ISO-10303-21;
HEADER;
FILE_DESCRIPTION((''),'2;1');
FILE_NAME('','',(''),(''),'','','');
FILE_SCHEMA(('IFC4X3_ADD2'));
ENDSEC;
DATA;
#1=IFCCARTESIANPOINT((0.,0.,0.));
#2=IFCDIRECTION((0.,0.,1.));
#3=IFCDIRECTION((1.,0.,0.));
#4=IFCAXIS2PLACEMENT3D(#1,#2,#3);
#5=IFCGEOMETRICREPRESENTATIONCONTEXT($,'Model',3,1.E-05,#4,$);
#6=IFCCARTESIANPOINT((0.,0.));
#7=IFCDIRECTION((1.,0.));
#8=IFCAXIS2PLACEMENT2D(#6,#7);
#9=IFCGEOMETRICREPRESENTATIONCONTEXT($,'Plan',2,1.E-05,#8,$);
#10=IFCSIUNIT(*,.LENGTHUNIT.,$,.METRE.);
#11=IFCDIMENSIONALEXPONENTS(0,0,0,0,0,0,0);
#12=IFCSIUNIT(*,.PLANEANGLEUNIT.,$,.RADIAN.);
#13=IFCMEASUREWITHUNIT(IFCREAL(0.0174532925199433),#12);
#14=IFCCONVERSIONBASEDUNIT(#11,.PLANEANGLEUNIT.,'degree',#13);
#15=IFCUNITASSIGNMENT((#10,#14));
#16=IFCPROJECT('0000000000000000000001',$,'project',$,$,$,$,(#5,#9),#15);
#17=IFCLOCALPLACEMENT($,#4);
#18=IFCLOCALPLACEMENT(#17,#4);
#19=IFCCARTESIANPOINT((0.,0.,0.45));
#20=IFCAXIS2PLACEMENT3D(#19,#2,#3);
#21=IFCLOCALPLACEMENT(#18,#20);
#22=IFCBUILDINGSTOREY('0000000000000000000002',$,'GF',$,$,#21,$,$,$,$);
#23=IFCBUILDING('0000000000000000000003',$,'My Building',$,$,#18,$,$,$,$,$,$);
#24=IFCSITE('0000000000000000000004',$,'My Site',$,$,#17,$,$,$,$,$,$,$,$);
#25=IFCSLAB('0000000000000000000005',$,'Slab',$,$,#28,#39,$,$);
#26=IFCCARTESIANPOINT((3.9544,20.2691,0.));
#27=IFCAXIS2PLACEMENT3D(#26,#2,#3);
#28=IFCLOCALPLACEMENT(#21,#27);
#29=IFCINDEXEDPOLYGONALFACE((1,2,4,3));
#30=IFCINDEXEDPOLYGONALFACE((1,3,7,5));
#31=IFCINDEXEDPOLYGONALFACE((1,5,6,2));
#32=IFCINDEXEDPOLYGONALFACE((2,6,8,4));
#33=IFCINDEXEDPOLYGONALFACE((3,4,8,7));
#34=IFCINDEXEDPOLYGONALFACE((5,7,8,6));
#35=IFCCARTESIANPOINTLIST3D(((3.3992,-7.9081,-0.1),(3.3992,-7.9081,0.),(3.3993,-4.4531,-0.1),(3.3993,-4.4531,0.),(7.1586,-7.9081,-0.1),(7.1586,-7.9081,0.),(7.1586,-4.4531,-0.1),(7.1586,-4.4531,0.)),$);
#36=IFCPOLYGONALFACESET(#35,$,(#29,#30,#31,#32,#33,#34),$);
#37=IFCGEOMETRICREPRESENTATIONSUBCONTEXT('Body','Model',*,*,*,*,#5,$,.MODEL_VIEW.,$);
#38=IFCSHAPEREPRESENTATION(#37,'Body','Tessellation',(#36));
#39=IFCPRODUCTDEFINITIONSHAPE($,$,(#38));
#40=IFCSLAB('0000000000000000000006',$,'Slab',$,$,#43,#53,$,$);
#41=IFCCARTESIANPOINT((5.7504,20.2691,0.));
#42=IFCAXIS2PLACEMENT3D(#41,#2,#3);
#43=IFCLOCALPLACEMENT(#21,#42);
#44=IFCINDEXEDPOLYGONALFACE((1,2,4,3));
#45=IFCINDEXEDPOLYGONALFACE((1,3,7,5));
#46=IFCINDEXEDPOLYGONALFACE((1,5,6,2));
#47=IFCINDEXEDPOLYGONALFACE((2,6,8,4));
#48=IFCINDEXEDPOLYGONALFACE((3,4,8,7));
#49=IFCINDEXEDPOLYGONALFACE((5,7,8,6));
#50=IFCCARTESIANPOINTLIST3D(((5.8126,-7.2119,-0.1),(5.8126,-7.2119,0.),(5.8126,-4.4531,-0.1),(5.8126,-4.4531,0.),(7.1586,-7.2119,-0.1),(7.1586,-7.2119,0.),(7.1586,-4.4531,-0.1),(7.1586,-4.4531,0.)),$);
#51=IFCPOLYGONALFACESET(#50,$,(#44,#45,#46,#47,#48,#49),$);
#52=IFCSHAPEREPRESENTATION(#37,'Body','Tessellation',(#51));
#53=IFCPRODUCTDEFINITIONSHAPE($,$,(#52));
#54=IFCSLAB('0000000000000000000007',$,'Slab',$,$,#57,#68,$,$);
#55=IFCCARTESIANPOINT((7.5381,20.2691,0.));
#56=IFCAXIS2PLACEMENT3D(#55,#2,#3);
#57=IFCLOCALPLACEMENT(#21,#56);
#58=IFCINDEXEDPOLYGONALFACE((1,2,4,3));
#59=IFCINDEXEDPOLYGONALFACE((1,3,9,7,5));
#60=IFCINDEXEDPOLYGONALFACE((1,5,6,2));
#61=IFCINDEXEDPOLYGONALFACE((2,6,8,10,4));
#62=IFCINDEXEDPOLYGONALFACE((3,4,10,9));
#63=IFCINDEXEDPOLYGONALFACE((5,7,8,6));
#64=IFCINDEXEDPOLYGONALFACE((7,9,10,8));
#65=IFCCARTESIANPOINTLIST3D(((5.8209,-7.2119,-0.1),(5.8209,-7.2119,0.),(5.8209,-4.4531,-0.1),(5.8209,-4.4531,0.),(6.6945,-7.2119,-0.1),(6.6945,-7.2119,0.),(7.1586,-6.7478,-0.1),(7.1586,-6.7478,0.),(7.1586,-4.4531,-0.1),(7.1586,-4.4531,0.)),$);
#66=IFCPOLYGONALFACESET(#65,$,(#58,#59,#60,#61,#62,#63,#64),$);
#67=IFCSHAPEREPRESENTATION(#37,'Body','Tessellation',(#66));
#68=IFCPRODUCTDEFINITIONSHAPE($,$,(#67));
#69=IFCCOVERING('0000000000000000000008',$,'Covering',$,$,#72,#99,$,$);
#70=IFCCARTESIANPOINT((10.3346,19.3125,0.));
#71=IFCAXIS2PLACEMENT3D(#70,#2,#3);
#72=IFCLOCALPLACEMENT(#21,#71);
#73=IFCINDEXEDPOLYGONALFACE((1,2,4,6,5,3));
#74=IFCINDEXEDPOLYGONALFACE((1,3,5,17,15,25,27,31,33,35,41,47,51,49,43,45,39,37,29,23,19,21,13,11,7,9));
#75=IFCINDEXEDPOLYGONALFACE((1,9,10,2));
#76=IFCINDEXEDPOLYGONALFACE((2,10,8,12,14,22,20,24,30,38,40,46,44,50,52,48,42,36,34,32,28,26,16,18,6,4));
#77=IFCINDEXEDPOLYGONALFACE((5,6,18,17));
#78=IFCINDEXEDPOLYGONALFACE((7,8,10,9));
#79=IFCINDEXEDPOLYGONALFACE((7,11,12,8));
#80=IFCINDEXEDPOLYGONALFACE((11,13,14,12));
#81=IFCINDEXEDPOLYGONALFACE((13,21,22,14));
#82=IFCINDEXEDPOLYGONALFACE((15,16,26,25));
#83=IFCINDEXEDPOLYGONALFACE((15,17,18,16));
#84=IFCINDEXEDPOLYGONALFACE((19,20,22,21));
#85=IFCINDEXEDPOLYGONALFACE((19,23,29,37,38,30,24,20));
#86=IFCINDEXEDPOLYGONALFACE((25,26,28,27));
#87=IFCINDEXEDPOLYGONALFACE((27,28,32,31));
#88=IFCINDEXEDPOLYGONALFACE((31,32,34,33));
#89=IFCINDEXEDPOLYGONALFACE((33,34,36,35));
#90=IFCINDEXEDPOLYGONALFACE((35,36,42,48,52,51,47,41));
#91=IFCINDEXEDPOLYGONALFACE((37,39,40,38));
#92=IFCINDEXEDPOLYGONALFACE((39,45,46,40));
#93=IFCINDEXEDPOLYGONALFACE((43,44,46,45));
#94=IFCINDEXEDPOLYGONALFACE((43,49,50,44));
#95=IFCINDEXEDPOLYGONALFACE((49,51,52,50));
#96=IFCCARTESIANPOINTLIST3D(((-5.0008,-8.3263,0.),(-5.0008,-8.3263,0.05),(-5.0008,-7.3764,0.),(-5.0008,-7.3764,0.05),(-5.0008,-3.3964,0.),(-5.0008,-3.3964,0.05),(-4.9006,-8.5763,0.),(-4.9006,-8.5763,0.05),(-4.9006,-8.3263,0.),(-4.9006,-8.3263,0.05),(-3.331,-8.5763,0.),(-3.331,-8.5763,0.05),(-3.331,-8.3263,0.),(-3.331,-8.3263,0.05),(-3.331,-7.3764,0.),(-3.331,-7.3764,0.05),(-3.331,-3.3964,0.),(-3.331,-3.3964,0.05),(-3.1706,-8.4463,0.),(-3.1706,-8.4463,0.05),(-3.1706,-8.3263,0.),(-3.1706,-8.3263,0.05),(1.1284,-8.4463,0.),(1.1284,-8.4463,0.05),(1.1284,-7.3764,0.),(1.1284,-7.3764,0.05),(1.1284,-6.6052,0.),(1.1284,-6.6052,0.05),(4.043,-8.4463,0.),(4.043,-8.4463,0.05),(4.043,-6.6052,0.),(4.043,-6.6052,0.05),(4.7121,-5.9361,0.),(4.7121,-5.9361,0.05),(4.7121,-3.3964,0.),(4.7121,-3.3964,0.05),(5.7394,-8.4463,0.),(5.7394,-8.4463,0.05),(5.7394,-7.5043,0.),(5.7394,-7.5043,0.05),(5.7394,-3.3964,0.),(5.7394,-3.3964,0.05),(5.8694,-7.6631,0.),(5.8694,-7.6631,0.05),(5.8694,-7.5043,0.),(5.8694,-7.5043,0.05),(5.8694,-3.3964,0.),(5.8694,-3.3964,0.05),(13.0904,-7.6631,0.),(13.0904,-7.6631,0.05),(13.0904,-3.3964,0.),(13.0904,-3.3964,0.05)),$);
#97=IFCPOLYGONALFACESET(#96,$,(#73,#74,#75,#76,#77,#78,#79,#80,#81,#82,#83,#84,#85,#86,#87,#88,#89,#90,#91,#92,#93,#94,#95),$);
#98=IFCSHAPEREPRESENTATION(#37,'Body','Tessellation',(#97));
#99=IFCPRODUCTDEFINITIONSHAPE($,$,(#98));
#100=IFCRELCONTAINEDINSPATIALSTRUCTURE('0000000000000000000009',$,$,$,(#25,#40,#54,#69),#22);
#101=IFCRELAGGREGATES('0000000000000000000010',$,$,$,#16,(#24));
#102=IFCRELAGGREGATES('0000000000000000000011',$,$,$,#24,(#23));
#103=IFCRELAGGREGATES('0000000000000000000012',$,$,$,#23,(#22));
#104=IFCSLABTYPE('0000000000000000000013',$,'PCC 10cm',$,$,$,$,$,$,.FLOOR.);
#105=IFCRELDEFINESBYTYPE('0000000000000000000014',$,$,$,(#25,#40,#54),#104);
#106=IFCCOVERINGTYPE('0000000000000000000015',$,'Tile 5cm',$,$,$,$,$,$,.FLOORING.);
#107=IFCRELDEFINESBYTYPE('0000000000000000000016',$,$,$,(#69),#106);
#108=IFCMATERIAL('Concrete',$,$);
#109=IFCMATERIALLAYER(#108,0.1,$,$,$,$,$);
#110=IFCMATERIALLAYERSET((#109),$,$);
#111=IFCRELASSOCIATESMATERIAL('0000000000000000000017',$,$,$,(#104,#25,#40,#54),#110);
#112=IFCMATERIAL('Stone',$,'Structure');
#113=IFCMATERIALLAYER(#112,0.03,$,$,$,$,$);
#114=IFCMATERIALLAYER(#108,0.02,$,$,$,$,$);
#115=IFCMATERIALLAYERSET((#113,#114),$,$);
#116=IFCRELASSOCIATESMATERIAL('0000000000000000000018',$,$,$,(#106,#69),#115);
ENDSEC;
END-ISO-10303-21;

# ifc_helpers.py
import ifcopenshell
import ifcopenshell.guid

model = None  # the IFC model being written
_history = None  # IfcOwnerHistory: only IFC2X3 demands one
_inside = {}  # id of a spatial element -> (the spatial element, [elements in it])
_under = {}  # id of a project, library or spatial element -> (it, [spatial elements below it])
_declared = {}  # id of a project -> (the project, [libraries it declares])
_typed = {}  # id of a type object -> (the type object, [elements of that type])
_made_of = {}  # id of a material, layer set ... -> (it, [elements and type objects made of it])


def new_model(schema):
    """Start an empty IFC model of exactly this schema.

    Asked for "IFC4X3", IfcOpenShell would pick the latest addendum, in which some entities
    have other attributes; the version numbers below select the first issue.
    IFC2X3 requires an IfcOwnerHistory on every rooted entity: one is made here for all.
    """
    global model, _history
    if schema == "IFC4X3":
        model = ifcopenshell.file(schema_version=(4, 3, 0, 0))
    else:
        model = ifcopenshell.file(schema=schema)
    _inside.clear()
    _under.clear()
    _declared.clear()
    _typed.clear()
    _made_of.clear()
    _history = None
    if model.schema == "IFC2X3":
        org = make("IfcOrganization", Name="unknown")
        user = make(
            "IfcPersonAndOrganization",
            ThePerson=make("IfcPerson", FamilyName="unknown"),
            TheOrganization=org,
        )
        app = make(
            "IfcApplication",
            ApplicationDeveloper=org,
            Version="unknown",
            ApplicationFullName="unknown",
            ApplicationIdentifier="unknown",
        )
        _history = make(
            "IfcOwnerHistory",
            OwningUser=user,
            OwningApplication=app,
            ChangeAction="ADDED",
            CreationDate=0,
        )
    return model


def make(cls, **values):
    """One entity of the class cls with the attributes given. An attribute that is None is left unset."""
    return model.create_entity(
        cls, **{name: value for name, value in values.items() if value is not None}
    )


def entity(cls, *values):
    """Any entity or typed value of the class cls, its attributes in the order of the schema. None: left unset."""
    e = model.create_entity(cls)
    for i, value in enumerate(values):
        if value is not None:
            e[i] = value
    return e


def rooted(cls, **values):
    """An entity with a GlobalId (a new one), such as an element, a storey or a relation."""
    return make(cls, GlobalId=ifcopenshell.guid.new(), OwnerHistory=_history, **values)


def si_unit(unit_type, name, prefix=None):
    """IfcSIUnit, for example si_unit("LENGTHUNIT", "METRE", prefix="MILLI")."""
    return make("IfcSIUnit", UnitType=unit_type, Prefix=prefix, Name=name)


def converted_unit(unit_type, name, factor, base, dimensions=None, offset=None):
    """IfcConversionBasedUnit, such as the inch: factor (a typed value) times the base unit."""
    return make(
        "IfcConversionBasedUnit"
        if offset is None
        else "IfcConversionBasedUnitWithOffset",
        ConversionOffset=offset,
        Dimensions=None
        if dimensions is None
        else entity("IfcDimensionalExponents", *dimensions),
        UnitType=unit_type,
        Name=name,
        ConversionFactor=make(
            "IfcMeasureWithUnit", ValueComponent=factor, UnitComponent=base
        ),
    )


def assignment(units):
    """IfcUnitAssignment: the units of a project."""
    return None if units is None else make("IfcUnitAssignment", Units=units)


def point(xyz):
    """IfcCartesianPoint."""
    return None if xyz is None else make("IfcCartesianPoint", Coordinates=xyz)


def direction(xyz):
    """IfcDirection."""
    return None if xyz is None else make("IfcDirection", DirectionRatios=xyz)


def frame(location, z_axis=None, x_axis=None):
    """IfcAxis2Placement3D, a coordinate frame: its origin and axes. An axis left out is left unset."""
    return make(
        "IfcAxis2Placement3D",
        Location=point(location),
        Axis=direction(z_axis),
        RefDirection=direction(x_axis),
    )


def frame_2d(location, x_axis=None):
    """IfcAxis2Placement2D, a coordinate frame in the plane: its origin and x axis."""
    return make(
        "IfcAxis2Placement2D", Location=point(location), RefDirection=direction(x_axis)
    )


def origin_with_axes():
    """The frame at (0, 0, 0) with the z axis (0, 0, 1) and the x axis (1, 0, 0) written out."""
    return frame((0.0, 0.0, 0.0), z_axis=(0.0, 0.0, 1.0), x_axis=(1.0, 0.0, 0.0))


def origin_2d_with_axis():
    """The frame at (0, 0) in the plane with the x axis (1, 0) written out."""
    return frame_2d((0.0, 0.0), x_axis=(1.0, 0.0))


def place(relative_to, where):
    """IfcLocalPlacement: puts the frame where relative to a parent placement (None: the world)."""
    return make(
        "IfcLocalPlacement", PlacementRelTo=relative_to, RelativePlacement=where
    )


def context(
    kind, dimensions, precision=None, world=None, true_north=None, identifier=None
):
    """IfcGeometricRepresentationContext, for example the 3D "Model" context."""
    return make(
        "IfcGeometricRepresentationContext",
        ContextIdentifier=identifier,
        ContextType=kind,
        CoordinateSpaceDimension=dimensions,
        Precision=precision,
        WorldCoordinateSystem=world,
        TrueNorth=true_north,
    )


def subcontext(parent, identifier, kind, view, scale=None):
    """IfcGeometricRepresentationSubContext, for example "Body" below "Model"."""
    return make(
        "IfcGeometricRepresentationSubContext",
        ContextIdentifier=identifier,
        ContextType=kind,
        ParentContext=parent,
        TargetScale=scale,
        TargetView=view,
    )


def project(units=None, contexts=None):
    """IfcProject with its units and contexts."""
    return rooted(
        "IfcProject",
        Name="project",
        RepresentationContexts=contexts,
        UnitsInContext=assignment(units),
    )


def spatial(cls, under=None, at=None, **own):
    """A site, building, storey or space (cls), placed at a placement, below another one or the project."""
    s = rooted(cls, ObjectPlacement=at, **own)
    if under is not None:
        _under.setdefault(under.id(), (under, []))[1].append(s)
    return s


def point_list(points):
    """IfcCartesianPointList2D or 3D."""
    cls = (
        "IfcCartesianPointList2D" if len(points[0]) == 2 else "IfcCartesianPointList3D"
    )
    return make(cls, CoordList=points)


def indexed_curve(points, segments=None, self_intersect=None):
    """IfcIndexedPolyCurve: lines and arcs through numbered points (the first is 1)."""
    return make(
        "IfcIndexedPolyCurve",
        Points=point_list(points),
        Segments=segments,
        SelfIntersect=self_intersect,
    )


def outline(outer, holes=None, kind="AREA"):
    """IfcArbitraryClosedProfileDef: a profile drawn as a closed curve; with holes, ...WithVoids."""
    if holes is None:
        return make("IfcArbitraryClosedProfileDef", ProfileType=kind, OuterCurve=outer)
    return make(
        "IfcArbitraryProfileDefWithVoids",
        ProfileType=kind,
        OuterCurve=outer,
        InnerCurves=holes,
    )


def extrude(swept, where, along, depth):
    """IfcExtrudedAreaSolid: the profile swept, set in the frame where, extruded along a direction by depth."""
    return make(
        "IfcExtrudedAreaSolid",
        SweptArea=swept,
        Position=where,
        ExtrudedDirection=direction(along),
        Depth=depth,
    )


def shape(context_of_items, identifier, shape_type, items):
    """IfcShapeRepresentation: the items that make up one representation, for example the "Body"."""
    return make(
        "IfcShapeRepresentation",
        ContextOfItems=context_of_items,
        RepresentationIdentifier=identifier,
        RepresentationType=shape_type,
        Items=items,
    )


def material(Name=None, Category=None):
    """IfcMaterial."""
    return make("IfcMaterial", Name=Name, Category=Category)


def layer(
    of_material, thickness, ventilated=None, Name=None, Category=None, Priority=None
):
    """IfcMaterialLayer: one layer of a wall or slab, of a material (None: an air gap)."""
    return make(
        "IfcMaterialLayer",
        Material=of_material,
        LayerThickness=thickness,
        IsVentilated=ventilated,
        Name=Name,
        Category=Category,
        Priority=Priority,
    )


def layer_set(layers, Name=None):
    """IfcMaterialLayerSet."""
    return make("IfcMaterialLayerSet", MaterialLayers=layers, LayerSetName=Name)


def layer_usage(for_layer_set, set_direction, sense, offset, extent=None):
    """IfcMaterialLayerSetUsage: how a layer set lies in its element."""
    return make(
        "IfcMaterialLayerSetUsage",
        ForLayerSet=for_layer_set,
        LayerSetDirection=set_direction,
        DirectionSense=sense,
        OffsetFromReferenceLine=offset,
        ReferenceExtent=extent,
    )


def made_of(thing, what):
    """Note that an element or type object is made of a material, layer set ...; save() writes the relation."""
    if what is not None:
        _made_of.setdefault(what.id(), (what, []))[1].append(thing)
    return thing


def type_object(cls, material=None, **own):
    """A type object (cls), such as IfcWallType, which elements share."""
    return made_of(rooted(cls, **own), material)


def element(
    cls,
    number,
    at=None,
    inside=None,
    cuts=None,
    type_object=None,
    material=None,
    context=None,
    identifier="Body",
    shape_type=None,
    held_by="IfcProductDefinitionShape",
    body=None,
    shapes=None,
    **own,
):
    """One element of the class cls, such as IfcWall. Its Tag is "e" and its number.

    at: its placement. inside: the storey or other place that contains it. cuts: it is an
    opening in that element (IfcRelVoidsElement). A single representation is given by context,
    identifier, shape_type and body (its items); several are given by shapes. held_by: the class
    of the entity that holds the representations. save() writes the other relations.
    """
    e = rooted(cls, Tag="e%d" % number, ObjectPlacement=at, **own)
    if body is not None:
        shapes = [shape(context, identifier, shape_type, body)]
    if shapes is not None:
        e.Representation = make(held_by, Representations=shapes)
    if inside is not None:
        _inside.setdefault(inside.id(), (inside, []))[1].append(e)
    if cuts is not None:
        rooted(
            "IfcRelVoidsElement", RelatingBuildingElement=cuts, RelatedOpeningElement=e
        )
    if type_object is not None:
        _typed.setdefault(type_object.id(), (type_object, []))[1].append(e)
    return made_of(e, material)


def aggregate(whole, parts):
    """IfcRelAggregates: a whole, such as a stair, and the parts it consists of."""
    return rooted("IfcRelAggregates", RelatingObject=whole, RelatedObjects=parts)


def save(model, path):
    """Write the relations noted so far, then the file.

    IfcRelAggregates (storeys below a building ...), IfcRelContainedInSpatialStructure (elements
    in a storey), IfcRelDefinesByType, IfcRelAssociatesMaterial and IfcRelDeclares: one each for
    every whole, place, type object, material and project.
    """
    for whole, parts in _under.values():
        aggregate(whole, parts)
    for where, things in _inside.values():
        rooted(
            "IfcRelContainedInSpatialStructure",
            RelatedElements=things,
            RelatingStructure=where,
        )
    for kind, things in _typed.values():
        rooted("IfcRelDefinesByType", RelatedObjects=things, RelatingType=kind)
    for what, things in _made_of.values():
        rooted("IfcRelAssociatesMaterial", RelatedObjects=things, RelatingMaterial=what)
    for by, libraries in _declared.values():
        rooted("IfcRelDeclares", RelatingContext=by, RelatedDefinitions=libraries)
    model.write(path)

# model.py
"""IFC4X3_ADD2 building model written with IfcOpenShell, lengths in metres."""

from ifc_helpers import new_model, entity, si_unit, converted_unit, frame, origin_with_axes, origin_2d_with_axis, place, context, subcontext, project, spatial, indexed_curve, outline, extrude, material, layer, layer_set, layer_usage, type_object, element, save


model = new_model("IFC4X3_ADD2")

# Units and contexts
model_context = context("Model", 3, precision=1e-05, world=origin_with_axes())
plan_context = context("Plan", 2, precision=1e-05, world=origin_2d_with_axis())
body_context = subcontext(model_context, "Body", "Model", "MODEL_VIEW")
ifc_project = project(units=[si_unit("LENGTHUNIT", "METRE"), converted_unit("PLANEANGLEUNIT", "degree", entity("IfcReal", 0.0174532925199433), si_unit("PLANEANGLEUNIT", "RADIAN"), dimensions=[0, 0, 0, 0, 0, 0, 0])], contexts=[model_context, plan_context])

# Site, building, storey
site_placement = place(None, origin_with_axes())
site = spatial("IfcSite", under=ifc_project, at=site_placement, Name="My Site")
building_placement = place(site_placement, origin_with_axes())
building = spatial("IfcBuilding", under=site, at=building_placement, Name="My Building")
storey_placement = place(building_placement, frame((0.0, 0.0, 0.45), z_axis=(0.0, 0.0, 1.0), x_axis=(1.0, 0.0, 0.0)))
storey = spatial("IfcBuildingStorey", under=building, at=storey_placement, Name="GF")

# Slabs
ifc_material_1 = material(Name="Concrete")
ifc_layer_1 = layer(ifc_material_1, 0.1)
ifc_layer_set_1 = layer_set([ifc_layer_1])
ifc_layer_usage_1 = layer_usage(ifc_layer_set_1, "AXIS3", "POSITIVE", -0.1)
slab_type = type_object("IfcSlabType", Name="PCC 10cm", PredefinedType="FLOOR", material=ifc_layer_set_1)
slab_1_placement = place(storey_placement, frame((3.9544, 20.2691, 0.0), z_axis=(0.0, 0.0, 1.0), x_axis=(1.0, 0.0, 0.0)))
element("IfcSlab", 1, at=slab_1_placement, inside=storey, type_object=slab_type, material=ifc_layer_usage_1, Name="Slab", context=body_context, shape_type="SweptSolid", body=[
    extrude(outline(indexed_curve([(3.3992, -7.9081), (7.1586, -7.9081), (7.1586, -4.4531), (3.3993, -4.4531), (3.3992, -7.9081)])), frame((0.0, 0.0, -0.1), z_axis=(0.0, 0.0, 1.0), x_axis=(1.0, 0.0, 0.0)), (0.0, 0.0, 1.0), 0.1),
])
ifc_layer_usage_2 = layer_usage(ifc_layer_set_1, "AXIS3", "POSITIVE", -0.1)
slab_2_placement = place(storey_placement, frame((5.7504, 20.2691, 0.0), z_axis=(0.0, 0.0, 1.0), x_axis=(1.0, 0.0, 0.0)))
element("IfcSlab", 2, at=slab_2_placement, inside=storey, type_object=slab_type, material=ifc_layer_usage_2, Name="Slab", context=body_context, shape_type="SweptSolid", body=[
    extrude(outline(indexed_curve([(5.8126, -4.4531), (7.1586, -4.4531), (7.1586, -7.2119), (5.8126, -7.2119), (5.8126, -4.4531)])), frame((0.0, 0.0, -0.1), z_axis=(0.0, 0.0, 1.0), x_axis=(1.0, 0.0, 0.0)), (0.0, 0.0, 1.0), 0.1),
])
ifc_layer_usage_3 = layer_usage(ifc_layer_set_1, "AXIS3", "POSITIVE", -0.1)
slab_3_placement = place(storey_placement, frame((7.5381, 20.2691, 0.0), z_axis=(0.0, 0.0, 1.0), x_axis=(1.0, 0.0, 0.0)))
element("IfcSlab", 3, at=slab_3_placement, inside=storey, type_object=slab_type, material=ifc_layer_usage_3, Name="Slab", context=body_context, shape_type="SweptSolid", body=[
    extrude(outline(indexed_curve([(7.1586, -4.4531), (5.8209, -4.4531), (5.8209, -7.2119), (6.6945, -7.2119), (7.1586, -6.7478), (7.1586, -4.4531)])), frame((0.0, 0.0, -0.1), z_axis=(0.0, 0.0, 1.0), x_axis=(1.0, 0.0, 0.0)), (0.0, 0.0, 1.0), 0.1),
])

# Covering
ifc_material_2 = material(Name="Stone", Category="Structure")
ifc_layer_2 = layer(ifc_material_2, 0.03)
ifc_layer_3 = layer(ifc_material_1, 0.02)
ifc_layer_set_2 = layer_set([ifc_layer_2, ifc_layer_3])
ifc_layer_usage_4 = layer_usage(ifc_layer_set_2, "AXIS3", "POSITIVE", 0.0)
covering_type = type_object("IfcCoveringType", Name="Tile 5cm", PredefinedType="FLOORING", material=ifc_layer_set_2)
covering_placement = place(storey_placement, frame((10.3346, 19.3125, 0.0), z_axis=(0.0, 0.0, 1.0), x_axis=(1.0, 0.0, 0.0)))
element("IfcCovering", 4, at=covering_placement, inside=storey, type_object=covering_type, material=ifc_layer_usage_4, Name="Covering", context=body_context, shape_type="SweptSolid", body=[
    extrude(outline(indexed_curve([(-3.1706, -8.3263), (-3.331, -8.3263), (-3.331, -8.5763), (-4.9006, -8.5763), (-4.9006, -8.3263), (-5.0008, -8.3263), (-5.0008, -7.3764), (-5.0008, -3.3964), (-3.331, -3.3964), (-3.331, -7.3764), (1.1284, -7.3764), (1.1284, -6.6052), (4.043, -6.6052), (4.7121, -5.9361), (4.7121, -3.3964), (5.7394, -3.3964), (5.8694, -3.3964), (13.0904, -3.3964), (13.0904, -7.6631), (5.8694, -7.6631), (5.8694, -7.5043), (5.7394, -7.5043), (5.7394, -8.4463), (4.043, -8.4463), (1.1284, -8.4463), (-3.1706, -8.4463), (-3.1706, -8.3263)])), None, (0.0, 0.0, 1.0), 0.05),
])

save(model, "model.ifc")
